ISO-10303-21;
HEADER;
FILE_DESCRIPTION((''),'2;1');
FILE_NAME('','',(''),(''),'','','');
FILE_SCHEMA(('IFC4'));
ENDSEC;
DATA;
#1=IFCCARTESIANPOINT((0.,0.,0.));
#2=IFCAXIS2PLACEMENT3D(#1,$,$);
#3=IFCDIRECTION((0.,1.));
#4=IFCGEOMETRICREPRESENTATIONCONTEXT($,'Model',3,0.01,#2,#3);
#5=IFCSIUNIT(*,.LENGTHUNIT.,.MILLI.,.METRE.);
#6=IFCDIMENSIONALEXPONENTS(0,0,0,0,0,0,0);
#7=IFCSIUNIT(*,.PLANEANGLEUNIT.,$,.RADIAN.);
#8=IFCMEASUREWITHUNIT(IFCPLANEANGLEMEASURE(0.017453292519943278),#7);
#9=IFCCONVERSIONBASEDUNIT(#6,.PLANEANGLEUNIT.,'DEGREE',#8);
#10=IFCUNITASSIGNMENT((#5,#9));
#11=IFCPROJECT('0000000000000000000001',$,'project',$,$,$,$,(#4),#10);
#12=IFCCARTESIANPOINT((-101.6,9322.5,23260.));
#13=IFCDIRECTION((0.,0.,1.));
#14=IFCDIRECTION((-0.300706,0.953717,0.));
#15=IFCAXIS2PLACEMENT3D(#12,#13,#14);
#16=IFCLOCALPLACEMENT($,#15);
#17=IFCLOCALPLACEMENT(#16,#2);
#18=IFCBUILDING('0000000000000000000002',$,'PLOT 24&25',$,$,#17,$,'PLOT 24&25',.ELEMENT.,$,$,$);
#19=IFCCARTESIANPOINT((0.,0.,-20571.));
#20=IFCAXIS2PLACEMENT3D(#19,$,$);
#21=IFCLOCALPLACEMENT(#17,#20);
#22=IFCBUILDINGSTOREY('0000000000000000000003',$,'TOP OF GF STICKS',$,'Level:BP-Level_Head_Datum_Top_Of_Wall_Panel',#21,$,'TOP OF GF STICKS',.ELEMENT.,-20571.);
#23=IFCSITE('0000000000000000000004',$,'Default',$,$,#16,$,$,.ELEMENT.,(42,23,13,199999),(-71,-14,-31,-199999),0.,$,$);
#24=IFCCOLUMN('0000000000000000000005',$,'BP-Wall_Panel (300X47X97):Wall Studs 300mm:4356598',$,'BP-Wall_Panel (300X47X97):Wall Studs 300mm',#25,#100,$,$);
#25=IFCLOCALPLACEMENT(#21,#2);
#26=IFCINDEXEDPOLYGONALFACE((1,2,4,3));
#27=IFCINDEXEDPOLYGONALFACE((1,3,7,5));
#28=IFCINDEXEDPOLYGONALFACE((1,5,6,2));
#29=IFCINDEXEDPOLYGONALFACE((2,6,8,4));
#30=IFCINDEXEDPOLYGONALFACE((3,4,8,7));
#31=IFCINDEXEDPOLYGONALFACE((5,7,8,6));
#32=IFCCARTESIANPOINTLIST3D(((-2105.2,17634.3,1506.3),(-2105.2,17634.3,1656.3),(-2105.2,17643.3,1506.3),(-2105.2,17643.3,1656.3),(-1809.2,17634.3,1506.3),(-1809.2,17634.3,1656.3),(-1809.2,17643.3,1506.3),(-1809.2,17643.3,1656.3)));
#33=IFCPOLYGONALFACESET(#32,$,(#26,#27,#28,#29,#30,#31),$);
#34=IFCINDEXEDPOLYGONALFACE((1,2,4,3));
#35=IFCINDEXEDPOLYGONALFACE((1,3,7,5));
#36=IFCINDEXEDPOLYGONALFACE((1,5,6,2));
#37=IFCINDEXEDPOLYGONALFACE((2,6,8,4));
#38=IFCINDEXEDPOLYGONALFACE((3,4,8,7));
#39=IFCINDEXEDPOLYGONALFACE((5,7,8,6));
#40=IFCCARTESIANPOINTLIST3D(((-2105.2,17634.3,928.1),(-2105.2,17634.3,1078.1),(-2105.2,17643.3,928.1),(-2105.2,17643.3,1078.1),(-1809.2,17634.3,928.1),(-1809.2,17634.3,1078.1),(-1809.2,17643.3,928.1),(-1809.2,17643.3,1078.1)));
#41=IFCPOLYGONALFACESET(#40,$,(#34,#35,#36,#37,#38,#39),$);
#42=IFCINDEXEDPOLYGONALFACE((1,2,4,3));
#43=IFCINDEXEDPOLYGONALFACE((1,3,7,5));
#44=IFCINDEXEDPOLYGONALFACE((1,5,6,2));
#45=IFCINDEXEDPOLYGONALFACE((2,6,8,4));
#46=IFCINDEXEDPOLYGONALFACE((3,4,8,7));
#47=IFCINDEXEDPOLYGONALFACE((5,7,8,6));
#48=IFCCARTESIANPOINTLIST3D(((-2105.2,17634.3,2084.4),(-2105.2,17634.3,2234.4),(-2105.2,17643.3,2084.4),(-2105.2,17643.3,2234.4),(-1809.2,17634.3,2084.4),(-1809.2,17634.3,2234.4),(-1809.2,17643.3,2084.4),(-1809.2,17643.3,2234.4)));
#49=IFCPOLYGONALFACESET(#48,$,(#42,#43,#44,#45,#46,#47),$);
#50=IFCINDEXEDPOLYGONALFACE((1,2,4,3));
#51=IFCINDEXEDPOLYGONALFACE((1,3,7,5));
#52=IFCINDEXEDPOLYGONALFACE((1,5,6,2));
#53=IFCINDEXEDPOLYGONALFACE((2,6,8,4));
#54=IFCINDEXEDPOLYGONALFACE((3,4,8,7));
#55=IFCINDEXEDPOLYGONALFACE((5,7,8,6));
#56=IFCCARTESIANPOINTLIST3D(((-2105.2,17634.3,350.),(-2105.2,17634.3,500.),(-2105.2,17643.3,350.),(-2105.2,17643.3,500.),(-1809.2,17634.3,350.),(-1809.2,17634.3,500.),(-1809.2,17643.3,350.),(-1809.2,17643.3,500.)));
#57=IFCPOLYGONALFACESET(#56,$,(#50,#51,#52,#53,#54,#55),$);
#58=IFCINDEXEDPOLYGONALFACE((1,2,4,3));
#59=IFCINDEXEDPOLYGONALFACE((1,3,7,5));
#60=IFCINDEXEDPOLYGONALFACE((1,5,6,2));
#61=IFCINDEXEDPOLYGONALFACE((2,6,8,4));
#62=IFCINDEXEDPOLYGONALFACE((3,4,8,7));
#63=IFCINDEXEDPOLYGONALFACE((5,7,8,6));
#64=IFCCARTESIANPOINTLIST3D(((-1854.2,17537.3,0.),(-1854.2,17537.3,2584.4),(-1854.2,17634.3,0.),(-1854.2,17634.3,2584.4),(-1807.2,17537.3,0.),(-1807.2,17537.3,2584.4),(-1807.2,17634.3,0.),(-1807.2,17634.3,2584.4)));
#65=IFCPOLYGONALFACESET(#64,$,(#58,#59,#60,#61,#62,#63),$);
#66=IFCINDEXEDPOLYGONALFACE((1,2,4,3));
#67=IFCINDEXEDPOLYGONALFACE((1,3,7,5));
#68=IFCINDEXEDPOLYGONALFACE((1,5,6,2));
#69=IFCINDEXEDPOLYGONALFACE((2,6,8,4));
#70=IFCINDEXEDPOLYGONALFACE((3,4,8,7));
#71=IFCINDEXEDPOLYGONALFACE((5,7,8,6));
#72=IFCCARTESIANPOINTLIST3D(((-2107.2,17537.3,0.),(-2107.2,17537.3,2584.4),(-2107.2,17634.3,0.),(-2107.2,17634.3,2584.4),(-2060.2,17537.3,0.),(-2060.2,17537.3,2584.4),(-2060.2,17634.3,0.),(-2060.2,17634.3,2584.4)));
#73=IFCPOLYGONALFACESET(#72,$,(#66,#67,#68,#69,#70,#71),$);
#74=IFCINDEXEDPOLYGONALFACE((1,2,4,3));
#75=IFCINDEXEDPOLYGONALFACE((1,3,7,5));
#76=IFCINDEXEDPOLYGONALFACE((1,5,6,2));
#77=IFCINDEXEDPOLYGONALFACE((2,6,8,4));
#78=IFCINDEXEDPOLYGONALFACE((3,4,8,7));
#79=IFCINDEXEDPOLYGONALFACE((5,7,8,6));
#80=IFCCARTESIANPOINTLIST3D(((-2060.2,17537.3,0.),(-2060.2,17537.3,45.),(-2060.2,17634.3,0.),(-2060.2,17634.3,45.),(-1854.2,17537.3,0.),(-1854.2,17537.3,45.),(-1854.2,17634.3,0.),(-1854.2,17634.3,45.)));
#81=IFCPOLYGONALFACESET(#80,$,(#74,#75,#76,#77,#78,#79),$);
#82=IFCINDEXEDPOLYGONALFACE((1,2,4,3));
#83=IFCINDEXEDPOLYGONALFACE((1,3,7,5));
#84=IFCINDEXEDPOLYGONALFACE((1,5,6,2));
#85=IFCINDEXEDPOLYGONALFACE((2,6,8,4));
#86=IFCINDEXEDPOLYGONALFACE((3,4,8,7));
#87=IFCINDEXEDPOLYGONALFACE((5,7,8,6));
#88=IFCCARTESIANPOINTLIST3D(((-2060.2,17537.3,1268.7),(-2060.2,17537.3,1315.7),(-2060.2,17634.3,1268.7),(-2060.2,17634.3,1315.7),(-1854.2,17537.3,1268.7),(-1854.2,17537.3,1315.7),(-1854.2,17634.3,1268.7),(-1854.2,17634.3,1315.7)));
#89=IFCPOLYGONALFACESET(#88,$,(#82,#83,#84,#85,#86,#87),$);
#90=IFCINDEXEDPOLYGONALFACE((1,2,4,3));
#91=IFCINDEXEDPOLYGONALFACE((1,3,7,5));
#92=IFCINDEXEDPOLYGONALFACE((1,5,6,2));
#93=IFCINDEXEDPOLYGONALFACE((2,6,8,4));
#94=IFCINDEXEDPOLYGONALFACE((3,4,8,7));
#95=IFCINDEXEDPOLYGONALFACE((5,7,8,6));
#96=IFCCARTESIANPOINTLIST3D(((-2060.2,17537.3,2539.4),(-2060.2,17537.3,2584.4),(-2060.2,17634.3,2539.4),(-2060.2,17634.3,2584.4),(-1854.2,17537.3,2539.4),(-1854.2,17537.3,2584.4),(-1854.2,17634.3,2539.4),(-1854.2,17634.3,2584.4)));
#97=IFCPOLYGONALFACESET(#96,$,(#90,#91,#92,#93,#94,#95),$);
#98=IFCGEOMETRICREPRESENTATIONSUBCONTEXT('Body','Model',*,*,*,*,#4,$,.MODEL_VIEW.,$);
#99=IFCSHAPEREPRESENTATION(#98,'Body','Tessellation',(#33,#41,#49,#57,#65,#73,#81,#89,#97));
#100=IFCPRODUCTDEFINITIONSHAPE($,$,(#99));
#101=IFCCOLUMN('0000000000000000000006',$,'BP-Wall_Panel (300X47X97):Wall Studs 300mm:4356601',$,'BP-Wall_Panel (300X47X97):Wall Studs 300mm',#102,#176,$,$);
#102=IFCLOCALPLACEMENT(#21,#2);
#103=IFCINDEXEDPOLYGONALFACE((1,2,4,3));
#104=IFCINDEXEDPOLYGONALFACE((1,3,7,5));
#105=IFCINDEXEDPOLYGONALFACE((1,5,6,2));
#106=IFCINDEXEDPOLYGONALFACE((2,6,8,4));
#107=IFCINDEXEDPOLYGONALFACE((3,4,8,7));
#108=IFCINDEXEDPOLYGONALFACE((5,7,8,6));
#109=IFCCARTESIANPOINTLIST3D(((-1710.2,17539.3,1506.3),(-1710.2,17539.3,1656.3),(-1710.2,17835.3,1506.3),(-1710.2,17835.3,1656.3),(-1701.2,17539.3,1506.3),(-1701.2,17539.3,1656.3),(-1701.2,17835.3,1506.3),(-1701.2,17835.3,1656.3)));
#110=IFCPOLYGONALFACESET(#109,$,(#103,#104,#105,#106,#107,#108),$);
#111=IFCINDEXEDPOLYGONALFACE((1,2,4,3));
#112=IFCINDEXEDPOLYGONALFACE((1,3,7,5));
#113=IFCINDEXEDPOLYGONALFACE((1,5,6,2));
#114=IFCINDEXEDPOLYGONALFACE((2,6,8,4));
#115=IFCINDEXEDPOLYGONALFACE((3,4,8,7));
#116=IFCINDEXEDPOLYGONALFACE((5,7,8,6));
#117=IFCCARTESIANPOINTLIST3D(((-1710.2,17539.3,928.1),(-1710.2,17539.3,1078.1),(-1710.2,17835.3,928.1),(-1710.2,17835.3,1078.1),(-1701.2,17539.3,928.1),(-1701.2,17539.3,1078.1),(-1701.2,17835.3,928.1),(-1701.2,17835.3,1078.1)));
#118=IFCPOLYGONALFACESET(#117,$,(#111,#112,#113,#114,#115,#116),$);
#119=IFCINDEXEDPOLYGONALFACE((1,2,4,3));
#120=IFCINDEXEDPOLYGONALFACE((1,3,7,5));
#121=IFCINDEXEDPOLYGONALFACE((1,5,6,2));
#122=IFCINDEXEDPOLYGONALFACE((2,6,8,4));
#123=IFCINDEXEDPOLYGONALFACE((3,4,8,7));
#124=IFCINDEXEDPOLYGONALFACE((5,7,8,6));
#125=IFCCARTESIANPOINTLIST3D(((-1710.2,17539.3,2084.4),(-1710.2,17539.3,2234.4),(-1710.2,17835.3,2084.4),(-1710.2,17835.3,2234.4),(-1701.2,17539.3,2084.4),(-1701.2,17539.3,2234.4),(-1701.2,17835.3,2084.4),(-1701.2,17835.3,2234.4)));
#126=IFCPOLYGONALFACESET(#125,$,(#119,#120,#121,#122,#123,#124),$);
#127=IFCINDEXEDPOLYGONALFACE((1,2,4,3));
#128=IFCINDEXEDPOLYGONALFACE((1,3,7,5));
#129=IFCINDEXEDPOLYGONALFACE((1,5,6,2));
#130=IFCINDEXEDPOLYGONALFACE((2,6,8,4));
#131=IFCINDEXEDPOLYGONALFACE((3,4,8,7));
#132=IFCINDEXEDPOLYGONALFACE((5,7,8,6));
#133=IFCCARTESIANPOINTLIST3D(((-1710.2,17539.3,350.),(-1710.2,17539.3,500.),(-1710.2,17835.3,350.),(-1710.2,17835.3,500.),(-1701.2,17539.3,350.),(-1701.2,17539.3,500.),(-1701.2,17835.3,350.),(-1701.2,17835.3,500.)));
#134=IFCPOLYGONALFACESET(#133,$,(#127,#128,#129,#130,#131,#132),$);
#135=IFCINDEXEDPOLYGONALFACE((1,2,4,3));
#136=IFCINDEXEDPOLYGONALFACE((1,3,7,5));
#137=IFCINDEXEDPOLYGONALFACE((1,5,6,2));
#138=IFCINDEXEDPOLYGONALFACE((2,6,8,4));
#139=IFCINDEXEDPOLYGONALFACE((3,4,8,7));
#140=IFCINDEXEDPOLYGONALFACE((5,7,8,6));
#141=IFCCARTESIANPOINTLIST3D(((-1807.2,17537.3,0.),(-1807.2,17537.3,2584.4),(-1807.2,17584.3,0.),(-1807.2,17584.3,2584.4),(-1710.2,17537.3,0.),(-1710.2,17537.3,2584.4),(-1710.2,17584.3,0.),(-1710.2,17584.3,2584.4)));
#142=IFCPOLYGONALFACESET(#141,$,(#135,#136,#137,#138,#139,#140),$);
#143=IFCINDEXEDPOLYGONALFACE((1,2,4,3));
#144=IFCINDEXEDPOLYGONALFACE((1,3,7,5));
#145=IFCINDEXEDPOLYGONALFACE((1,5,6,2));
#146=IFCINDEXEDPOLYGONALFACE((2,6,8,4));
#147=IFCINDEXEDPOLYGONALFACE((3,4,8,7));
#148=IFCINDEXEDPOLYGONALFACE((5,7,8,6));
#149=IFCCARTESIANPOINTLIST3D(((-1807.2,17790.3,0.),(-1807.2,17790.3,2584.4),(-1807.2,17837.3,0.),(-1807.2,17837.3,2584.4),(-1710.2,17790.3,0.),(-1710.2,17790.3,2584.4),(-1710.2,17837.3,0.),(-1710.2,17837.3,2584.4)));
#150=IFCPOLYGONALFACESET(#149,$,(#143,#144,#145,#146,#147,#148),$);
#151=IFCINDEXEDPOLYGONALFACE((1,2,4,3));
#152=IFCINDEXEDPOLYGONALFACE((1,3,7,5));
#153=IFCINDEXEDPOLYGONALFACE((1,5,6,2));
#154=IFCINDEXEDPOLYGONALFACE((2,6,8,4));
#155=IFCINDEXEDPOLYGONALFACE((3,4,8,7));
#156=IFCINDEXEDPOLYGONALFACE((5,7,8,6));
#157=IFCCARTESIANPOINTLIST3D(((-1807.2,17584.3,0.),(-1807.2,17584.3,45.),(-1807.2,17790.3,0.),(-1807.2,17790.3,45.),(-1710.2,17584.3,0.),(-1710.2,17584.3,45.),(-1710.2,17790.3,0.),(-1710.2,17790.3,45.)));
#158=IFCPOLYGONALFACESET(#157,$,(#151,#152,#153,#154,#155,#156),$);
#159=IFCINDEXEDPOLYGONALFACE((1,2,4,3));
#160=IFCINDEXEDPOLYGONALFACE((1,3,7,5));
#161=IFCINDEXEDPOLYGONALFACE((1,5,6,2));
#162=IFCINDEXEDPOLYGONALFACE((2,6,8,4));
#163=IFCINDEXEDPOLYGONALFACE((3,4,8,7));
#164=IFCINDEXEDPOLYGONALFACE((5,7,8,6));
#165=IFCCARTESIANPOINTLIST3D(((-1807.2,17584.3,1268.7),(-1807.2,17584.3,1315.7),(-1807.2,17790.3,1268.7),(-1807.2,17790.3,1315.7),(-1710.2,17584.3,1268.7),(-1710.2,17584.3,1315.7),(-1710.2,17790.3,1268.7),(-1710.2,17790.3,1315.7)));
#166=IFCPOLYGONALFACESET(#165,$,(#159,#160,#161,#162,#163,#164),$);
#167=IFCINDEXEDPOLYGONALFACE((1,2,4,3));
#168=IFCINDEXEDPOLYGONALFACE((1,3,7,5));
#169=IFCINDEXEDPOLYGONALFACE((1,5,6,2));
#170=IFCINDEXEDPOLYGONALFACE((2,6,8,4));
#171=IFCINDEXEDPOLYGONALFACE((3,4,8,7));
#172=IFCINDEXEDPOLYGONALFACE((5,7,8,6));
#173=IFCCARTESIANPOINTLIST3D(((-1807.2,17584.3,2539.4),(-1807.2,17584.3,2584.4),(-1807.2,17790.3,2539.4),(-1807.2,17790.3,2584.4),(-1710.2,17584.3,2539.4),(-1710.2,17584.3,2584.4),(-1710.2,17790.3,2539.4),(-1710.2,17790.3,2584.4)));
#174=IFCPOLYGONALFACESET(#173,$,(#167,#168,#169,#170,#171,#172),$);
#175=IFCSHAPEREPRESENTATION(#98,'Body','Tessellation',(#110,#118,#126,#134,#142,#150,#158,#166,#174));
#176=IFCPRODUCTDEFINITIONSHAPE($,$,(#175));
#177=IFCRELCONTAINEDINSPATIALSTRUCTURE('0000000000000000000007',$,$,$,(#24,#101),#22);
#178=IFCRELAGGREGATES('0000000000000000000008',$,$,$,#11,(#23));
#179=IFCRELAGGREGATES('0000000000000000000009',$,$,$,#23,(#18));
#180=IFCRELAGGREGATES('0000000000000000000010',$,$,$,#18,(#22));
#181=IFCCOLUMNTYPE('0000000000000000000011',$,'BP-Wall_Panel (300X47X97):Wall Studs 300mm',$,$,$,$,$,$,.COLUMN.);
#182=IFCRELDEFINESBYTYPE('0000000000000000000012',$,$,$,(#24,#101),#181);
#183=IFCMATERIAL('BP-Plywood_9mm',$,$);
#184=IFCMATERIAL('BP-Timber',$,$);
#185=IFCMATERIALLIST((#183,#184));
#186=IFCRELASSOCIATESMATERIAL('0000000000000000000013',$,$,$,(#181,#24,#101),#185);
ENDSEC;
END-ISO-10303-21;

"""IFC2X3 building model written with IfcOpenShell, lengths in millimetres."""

from ifc_helpers import new_model, entity, si_unit, converted_unit, direction, frame, frame_2d, origin, origin_2d_with_axis, place, context, subcontext, project, spatial, rectangle, extrude, source, transform, mapped, material, material_list, type_object, type_shapes, element, save


model = new_model("IFC2X3")

# Units and contexts
model_context = context("Model", 3, precision=0.01, world=origin(), true_north=direction((0.0, 1.0)))
body_context = subcontext(model_context, "Body", "Model", "MODEL_VIEW")
ifc_project = project(units=[si_unit("LENGTHUNIT", "METRE", prefix="MILLI"), converted_unit("PLANEANGLEUNIT", "DEGREE", entity("IfcPlaneAngleMeasure", 0.017453292519943278), si_unit("PLANEANGLEUNIT", "RADIAN"), dimensions=[0, 0, 0, 0, 0, 0, 0])], contexts=[model_context])

# Site, building, storey
site_placement = place(None, frame((-101.6, 9322.5, 23260.0), z_axis=(0.0, 0.0, 1.0), x_axis=(-0.300706, 0.953717, 0.0)))
site = spatial("IfcSite", under=ifc_project, at=site_placement, Name="Default", CompositionType="ELEMENT", RefLatitude=(42, 23, 13, 199999), RefLongitude=(-71, -14, -31, -199999), RefElevation=0.0)
building_placement = place(site_placement, origin())
building = spatial("IfcBuilding", under=site, at=building_placement, Name="PLOT 24&25", LongName="PLOT 24&25", CompositionType="ELEMENT")
storey_placement = place(building_placement, frame((0.0, 0.0, -20571.0)))
storey = spatial("IfcBuildingStorey", under=building, at=storey_placement, Name="TOP OF GF STICKS", ObjectType="Level:BP-Level_Head_Datum_Top_Of_Wall_Panel", LongName="TOP OF GF STICKS", CompositionType="ELEMENT", Elevation=-20571.0)

# Columns
ifc_material_1 = material(Name="BP-Plywood_9mm")
ifc_material_2 = material(Name="BP-Timber")
ifc_material_list = material_list([ifc_material_1, ifc_material_2])
column_type_1 = type_object("IfcColumnType", Name="BP-Wall_Panel (300X47X97):Wall Studs 300mm", PredefinedType="COLUMN", material=ifc_material_list)
shared_shape_1 = source(origin(), body_context, "Body", "SweptSolid", [
    extrude(rectangle(XDim=296.0, YDim=9.0, at=origin_2d_with_axis()), frame((53.0, 0.0, -19064.7), z_axis=(0.0, 0.0, 1.0), x_axis=(0.0, -1.0, 0.0)), (0.0, 0.0, 1.0), 150.0),
    extrude(rectangle(XDim=296.0, YDim=9.0, at=origin_2d_with_axis()), frame((53.0, 0.0, -19642.9), z_axis=(0.0, 0.0, 1.0), x_axis=(0.0, -1.0, 0.0)), (0.0, 0.0, 1.0), 150.0),
    extrude(rectangle(XDim=296.0, YDim=9.0, at=origin_2d_with_axis()), frame((53.0, 0.0, -18486.6), z_axis=(0.0, 0.0, 1.0), x_axis=(0.0, -1.0, 0.0)), (0.0, 0.0, 1.0), 150.0),
    extrude(rectangle(XDim=296.0, YDim=9.0, at=origin_2d_with_axis()), frame((53.0, 0.0, -20221.0), z_axis=(0.0, 0.0, 1.0), x_axis=(0.0, -1.0, 0.0)), (0.0, 0.0, 1.0), 150.0),
    extrude(rectangle(XDim=97.0, YDim=47.0, at=origin_2d_with_axis()), frame((0.0, -126.5, -20571.0), z_axis=(0.0, 0.0, 1.0), x_axis=(-1.0, 0.0, 0.0)), (0.0, 0.0, 1.0), 2584.4),
    extrude(rectangle(XDim=97.0, YDim=47.0, at=frame_2d((0.0, 0.0), x_axis=(1.0, 0.0))), frame((0.0, 126.5, -20571.0), z_axis=(0.0, 0.0, 1.0), x_axis=(-1.0, 0.0, 0.0)), (0.0, 0.0, 1.0), 2584.4),
    extrude(rectangle(XDim=206.0, YDim=97.0, at=origin_2d_with_axis()), frame((0.0, 0.0, -20571.0), z_axis=(0.0, 0.0, 1.0), x_axis=(0.0, -1.0, 0.0)), (0.0, 0.0, 1.0), 45.0),
    extrude(rectangle(XDim=206.0, YDim=97.0, at=origin_2d_with_axis()), frame((0.0, 0.0, -19302.3), z_axis=(0.0, 0.0, 1.0), x_axis=(0.0, -1.0, 0.0)), (0.0, 0.0, 1.0), 47.0),
    extrude(rectangle(XDim=206.0, YDim=97.0, at=origin_2d_with_axis()), frame((0.0, 0.0, -18031.6), z_axis=(0.0, 0.0, 1.0), x_axis=(0.0, -1.0, 0.0)), (0.0, 0.0, 1.0), 45.0),
])
type_shapes(column_type_1, [shared_shape_1])
column_1_placement = place(storey_placement, frame((-1957.2, 17585.8, 20571.0), z_axis=(0.0, 0.0, 1.0), x_axis=(0.0, 1.0, 0.0)))
element("IfcColumn", 1, at=column_1_placement, inside=storey, type_object=column_type_1, material=ifc_material_list, Name="BP-Wall_Panel (300X47X97):Wall Studs 300mm:4356598", ObjectType="BP-Wall_Panel (300X47X97):Wall Studs 300mm", context=body_context, shape_type="MappedRepresentation", body=[
    mapped(shared_shape_1, transform((0.0, 0.0, 0.0), scale=1.0)),
])
column_2_placement = place(storey_placement, frame((-1758.7, 17687.3, 20571.0)))
element("IfcColumn", 2, at=column_2_placement, inside=storey, type_object=column_type_1, material=ifc_material_list, Name="BP-Wall_Panel (300X47X97):Wall Studs 300mm:4356601", ObjectType="BP-Wall_Panel (300X47X97):Wall Studs 300mm", context=body_context, shape_type="MappedRepresentation", body=[
    mapped(shared_shape_1, transform((0.0, 0.0, 0.0), scale=1.0)),
])

save(model, "model.ifc")
